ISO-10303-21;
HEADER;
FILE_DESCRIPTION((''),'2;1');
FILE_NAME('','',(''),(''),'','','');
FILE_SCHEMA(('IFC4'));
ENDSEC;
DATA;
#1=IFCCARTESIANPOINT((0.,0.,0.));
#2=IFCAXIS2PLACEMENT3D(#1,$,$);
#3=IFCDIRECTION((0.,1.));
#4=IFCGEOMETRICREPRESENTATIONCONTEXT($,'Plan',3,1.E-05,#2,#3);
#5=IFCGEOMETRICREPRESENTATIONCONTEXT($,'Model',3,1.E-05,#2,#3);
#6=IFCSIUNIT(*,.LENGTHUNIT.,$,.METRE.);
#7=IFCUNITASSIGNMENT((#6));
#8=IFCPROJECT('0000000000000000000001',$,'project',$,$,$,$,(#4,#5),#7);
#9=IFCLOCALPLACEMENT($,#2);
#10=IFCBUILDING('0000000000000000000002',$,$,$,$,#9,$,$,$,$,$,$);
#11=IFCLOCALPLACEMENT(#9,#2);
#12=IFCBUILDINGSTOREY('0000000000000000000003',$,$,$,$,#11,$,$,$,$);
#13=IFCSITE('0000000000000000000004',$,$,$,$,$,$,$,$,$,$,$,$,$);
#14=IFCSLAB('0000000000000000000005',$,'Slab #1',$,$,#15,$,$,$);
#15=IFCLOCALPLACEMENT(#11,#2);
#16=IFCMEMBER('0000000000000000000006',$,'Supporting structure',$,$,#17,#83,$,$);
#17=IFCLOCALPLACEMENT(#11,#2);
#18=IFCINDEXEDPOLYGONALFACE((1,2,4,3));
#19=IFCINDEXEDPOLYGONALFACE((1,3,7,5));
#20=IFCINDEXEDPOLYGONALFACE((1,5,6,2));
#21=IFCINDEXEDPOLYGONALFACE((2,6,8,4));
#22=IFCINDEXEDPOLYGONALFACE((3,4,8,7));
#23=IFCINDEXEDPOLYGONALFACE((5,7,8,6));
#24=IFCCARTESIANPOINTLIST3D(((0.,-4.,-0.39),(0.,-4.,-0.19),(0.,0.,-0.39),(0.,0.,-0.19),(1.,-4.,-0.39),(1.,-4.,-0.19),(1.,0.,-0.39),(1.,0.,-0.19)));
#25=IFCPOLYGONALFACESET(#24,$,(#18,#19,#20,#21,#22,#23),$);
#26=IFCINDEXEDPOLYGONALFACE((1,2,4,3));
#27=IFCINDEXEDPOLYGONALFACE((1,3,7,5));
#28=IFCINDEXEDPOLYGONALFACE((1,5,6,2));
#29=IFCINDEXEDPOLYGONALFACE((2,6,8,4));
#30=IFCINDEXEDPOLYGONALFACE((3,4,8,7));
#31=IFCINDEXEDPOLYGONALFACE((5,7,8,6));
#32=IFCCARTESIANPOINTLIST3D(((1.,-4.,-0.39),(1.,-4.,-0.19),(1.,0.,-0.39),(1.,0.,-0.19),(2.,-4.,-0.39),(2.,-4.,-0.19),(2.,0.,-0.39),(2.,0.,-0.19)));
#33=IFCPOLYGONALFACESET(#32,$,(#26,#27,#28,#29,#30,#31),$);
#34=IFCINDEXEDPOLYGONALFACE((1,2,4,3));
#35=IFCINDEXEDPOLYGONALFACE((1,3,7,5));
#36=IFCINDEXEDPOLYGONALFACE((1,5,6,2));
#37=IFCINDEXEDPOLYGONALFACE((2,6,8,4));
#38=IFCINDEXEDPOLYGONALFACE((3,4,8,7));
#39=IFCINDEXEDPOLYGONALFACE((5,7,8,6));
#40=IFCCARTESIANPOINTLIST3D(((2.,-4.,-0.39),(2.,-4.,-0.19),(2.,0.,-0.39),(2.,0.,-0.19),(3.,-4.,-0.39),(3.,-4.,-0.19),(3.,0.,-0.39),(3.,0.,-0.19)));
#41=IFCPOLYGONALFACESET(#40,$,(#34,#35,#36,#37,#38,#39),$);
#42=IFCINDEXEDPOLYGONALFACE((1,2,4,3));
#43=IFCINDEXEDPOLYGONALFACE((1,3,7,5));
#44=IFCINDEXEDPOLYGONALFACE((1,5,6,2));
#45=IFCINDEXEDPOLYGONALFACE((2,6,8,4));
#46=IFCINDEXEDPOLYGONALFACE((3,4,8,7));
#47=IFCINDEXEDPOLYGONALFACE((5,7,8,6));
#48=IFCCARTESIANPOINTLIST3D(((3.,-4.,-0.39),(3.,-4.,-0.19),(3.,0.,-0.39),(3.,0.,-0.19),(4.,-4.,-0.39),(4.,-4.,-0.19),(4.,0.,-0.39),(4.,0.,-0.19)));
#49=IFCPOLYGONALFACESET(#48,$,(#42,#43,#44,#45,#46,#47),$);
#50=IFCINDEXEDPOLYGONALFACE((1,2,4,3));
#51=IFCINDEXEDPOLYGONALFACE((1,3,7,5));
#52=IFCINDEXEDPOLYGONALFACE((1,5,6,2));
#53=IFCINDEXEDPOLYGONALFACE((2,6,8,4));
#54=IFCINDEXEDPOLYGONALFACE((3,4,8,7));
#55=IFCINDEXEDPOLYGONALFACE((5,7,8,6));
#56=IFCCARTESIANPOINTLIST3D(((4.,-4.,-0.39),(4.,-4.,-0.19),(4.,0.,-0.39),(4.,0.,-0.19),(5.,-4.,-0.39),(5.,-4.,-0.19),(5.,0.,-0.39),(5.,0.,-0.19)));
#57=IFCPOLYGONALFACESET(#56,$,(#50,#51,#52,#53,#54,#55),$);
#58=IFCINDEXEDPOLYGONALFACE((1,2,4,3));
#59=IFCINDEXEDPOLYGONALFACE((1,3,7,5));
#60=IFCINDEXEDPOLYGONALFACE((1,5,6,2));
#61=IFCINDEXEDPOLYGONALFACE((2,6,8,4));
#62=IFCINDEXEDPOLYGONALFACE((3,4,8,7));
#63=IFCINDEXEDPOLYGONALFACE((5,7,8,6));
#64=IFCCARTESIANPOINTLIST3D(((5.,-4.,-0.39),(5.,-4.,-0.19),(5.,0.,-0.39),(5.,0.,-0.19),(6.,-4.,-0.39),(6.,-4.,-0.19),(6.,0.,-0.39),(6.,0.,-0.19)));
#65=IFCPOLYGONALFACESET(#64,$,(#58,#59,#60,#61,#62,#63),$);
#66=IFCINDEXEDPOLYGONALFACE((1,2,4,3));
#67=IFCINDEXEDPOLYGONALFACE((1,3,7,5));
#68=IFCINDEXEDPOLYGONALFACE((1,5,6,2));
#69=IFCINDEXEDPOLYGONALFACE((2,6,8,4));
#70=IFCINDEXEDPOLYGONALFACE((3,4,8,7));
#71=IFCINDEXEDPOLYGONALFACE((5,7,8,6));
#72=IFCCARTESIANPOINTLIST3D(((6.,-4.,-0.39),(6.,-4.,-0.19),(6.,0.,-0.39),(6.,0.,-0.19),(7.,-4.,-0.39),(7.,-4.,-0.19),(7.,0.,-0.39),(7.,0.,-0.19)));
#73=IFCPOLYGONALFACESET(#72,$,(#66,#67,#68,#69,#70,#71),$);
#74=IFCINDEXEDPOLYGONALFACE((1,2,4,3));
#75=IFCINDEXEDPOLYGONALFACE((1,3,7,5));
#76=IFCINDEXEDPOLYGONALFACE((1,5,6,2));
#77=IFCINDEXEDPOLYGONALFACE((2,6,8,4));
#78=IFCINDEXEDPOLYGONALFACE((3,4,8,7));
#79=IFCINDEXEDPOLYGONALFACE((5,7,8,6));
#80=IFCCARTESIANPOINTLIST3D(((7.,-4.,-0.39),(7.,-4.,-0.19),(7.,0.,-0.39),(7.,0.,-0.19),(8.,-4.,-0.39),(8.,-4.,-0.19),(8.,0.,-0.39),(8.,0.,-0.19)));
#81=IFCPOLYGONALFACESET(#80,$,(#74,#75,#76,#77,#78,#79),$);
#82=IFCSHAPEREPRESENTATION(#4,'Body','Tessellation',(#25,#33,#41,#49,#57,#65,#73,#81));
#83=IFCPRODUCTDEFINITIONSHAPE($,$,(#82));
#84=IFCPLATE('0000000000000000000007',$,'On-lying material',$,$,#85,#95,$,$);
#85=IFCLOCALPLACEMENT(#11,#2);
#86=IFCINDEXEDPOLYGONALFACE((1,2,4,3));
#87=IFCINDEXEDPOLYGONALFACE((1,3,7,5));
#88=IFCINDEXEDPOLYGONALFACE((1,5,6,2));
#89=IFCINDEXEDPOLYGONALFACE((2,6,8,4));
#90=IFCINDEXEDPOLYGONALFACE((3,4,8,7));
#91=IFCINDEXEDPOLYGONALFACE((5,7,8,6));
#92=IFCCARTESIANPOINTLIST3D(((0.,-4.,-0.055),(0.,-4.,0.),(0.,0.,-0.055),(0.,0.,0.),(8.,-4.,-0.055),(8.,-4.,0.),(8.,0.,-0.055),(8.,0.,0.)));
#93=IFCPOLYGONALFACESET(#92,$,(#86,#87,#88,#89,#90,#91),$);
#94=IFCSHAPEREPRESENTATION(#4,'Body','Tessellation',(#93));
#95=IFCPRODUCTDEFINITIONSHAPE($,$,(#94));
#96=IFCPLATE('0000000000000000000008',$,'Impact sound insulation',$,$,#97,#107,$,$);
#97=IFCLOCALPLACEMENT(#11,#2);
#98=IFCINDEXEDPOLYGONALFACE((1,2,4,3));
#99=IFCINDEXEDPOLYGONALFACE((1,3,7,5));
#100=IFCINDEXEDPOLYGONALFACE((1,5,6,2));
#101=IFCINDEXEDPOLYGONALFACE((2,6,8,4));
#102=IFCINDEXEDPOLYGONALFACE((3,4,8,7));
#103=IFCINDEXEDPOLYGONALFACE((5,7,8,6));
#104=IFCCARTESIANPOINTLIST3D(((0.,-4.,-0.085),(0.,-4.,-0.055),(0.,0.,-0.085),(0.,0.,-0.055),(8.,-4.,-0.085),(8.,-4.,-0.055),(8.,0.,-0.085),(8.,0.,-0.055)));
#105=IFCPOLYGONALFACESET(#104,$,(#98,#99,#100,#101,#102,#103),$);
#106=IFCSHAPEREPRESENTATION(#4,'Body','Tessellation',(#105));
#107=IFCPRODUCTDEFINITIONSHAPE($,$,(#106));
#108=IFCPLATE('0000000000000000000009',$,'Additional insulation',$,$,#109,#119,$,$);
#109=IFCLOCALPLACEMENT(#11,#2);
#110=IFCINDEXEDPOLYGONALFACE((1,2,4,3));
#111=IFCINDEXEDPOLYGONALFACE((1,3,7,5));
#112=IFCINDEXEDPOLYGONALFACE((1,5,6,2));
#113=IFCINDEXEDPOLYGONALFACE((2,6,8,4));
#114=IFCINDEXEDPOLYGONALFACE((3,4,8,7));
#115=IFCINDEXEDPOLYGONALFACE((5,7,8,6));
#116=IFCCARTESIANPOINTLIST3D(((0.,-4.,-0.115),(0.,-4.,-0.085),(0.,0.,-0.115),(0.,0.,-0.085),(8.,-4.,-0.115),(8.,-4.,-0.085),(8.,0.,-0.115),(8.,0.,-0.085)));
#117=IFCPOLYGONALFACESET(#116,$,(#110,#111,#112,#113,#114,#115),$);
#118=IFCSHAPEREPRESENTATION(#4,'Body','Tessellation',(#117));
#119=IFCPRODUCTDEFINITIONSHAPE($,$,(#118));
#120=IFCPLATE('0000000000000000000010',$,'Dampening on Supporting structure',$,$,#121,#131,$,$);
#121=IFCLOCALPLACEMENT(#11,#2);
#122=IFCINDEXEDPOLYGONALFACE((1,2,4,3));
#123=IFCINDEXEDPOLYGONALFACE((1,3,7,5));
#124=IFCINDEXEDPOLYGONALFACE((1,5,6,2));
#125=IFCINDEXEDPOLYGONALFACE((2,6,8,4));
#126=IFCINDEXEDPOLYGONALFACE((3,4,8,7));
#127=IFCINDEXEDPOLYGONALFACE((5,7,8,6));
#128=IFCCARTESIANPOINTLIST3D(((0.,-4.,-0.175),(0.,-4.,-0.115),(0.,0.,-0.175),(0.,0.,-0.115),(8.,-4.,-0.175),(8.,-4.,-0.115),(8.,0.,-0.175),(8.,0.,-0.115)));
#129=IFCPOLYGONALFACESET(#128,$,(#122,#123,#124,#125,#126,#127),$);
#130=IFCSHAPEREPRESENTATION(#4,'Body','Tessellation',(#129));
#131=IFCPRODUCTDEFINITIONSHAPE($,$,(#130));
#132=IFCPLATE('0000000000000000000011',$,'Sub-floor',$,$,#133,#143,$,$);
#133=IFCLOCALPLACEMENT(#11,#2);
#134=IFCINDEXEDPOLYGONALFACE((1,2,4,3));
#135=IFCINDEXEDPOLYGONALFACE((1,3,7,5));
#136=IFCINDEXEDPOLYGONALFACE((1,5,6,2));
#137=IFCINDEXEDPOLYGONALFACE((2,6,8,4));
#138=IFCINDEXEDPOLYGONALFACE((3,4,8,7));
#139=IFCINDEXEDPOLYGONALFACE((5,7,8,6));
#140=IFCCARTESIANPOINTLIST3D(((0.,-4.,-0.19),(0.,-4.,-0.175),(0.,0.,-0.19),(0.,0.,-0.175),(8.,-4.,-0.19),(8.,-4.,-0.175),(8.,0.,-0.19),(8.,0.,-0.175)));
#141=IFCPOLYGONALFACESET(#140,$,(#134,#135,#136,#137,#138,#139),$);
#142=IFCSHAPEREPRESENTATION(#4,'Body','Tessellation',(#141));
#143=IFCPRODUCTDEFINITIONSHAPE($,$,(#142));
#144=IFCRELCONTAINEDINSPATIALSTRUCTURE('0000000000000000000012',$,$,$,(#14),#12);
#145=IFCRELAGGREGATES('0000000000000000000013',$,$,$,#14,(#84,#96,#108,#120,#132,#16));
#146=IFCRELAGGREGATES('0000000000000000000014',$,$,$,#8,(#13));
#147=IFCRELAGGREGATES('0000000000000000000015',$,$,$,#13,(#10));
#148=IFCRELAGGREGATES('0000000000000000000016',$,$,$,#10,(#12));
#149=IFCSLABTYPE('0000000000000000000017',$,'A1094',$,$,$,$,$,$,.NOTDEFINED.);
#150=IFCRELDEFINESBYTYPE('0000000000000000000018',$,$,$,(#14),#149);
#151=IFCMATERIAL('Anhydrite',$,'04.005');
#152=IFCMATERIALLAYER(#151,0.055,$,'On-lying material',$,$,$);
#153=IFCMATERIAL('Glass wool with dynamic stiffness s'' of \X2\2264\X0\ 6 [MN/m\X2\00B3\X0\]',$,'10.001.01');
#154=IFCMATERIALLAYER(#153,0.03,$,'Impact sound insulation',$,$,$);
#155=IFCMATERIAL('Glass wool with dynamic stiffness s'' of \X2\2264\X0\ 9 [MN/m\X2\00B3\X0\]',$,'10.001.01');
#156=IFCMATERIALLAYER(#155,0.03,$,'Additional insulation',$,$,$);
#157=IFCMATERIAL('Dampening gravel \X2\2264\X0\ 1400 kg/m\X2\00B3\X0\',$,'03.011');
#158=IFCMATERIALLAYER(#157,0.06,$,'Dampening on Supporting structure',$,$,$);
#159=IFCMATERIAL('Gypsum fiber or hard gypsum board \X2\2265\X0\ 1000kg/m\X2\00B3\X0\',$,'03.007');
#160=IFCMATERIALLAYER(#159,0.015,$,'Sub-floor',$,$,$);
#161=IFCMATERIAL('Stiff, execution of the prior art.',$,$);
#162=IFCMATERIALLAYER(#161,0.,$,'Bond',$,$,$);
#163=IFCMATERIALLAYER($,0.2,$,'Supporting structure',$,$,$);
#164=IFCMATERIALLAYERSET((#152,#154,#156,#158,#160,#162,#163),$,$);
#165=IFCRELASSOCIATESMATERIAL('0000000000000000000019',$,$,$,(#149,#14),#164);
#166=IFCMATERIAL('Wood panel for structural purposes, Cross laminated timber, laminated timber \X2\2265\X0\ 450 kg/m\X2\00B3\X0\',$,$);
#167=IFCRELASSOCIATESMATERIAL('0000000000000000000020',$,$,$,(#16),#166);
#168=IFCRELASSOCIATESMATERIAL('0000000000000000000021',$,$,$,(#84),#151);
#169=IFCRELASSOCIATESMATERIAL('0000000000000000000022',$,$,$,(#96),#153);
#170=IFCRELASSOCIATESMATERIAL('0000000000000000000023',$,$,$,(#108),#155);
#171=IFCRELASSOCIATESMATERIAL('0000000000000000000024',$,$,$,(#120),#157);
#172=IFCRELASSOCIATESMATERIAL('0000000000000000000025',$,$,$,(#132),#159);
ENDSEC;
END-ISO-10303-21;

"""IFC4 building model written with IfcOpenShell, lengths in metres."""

from ifc_helpers import new_model, si_unit, direction, frame, frame_2d, origin, origin_with_axes, place, context, project, spatial, rectangle, extrude, material, layer, layer_set, type_object, element, aggregate, save


model = new_model("IFC4")

# Units and contexts
plan_context = context("Plan", 3, precision=1e-05, world=origin(), true_north=direction((0.0, 1.0)))
model_context = context("Model", 3, precision=1e-05, world=origin(), true_north=direction((0.0, 1.0)))
ifc_project = project(units=[si_unit("LENGTHUNIT", "METRE")], contexts=[plan_context, model_context])

# Site, building, storey
site = spatial("IfcSite", under=ifc_project)
building_placement = place(None, origin())
building = spatial("IfcBuilding", under=site, at=building_placement)
storey_placement = place(building_placement, origin())
storey = spatial("IfcBuildingStorey", under=building, at=storey_placement)

# Slab, member, plates
ifc_material_1 = material(Name="Anhydrite", Category="04.005")
ifc_layer_1 = layer(ifc_material_1, 0.055, Name="On-lying material")
ifc_material_2 = material(Name="Glass wool with dynamic stiffness s' of ≤ 6 [MN/m³]", Category="10.001.01")
ifc_layer_2 = layer(ifc_material_2, 0.03, Name="Impact sound insulation")
ifc_material_3 = material(Name="Glass wool with dynamic stiffness s' of ≤ 9 [MN/m³]", Category="10.001.01")
ifc_layer_3 = layer(ifc_material_3, 0.03, Name="Additional insulation")
ifc_material_4 = material(Name="Dampening gravel ≤ 1400 kg/m³", Category="03.011")
ifc_layer_4 = layer(ifc_material_4, 0.06, Name="Dampening on Supporting structure")
ifc_material_5 = material(Name="Gypsum fiber or hard gypsum board ≥ 1000kg/m³", Category="03.007")
ifc_layer_5 = layer(ifc_material_5, 0.015, Name="Sub-floor")
ifc_material_6 = material(Name="Stiff, execution of the prior art.")
ifc_layer_6 = layer(ifc_material_6, 0.0, Name="Bond")
ifc_layer_7 = layer(None, 0.2, Name="Supporting structure")
ifc_layer_set = layer_set([ifc_layer_1, ifc_layer_2, ifc_layer_3, ifc_layer_4, ifc_layer_5, ifc_layer_6, ifc_layer_7])
slab_type = type_object("IfcSlabType", Name="A1094", PredefinedType="NOTDEFINED", material=ifc_layer_set)
slab_placement = place(None, frame((0.0, 0.0, 0.0), z_axis=(0.0, 0.0, -1.0), x_axis=(1.0, 0.0, 0.0)))
slab = element("IfcSlab", 1, at=slab_placement, inside=storey, type_object=slab_type, material=ifc_layer_set, Name="Slab #1")
ifc_material_7 = material(Name="Wood panel for structural purposes, Cross laminated timber, laminated timber ≥ 450 kg/m³")
member_placement = place(slab_placement, origin())
member = element("IfcMember", 2, at=member_placement, material=ifc_material_7, Name="Supporting structure", context=plan_context, shape_type="SweptSolid", body=[
    extrude(rectangle(XDim=1.0, YDim=0.2, at=frame_2d((0.5, 0.1), x_axis=(1.0, 0.0))), frame((0.0, 4.0, 0.19), z_axis=(0.0, -1.0, 0.0), x_axis=(1.0, 0.0, 0.0)), (0.0, 0.0, 1.0), 4.0),
    extrude(rectangle(XDim=1.0, YDim=0.2, at=frame_2d((0.5, 0.1), x_axis=(1.0, 0.0))), frame((1.0, 4.0, 0.19), z_axis=(0.0, -1.0, 0.0), x_axis=(1.0, 0.0, 0.0)), (0.0, 0.0, 1.0), 4.0),
    extrude(rectangle(XDim=1.0, YDim=0.2, at=frame_2d((0.5, 0.1), x_axis=(1.0, 0.0))), frame((2.0, 4.0, 0.19), z_axis=(0.0, -1.0, 0.0), x_axis=(1.0, 0.0, 0.0)), (0.0, 0.0, 1.0), 4.0),
    extrude(rectangle(XDim=1.0, YDim=0.2, at=frame_2d((0.5, 0.1), x_axis=(1.0, 0.0))), frame((3.0, 4.0, 0.19), z_axis=(0.0, -1.0, 0.0), x_axis=(1.0, 0.0, 0.0)), (0.0, 0.0, 1.0), 4.0),
    extrude(rectangle(XDim=1.0, YDim=0.2, at=frame_2d((0.5, 0.1), x_axis=(1.0, 0.0))), frame((4.0, 4.0, 0.19), z_axis=(0.0, -1.0, 0.0), x_axis=(1.0, 0.0, 0.0)), (0.0, 0.0, 1.0), 4.0),
    extrude(rectangle(XDim=1.0, YDim=0.2, at=frame_2d((0.5, 0.1), x_axis=(1.0, 0.0))), frame((5.0, 4.0, 0.19), z_axis=(0.0, -1.0, 0.0), x_axis=(1.0, 0.0, 0.0)), (0.0, 0.0, 1.0), 4.0),
    extrude(rectangle(XDim=1.0, YDim=0.2, at=frame_2d((0.5, 0.1), x_axis=(1.0, 0.0))), frame((6.0, 4.0, 0.19), z_axis=(0.0, -1.0, 0.0), x_axis=(1.0, 0.0, 0.0)), (0.0, 0.0, 1.0), 4.0),
    extrude(rectangle(XDim=1.0, YDim=0.2, at=frame_2d((0.5, 0.1), x_axis=(1.0, 0.0))), frame((7.0, 4.0, 0.19), z_axis=(0.0, -1.0, 0.0), x_axis=(1.0, 0.0, 0.0)), (0.0, 0.0, 1.0), 4.0),
])
plate_1_placement = place(slab_placement, origin())
plate_1 = element("IfcPlate", 3, at=plate_1_placement, material=ifc_material_1, Name="On-lying material", context=plan_context, shape_type="SweptSolid", body=[
    extrude(rectangle(XDim=8.0, YDim=4.0, at=frame_2d((4.0, 2.0), x_axis=(1.0, 0.0))), origin_with_axes(), (0.0, 0.0, 1.0), 0.055),
])
plate_2_placement = place(slab_placement, origin())
plate_2 = element("IfcPlate", 4, at=plate_2_placement, material=ifc_material_2, Name="Impact sound insulation", context=plan_context, shape_type="SweptSolid", body=[
    extrude(rectangle(XDim=8.0, YDim=4.0, at=frame_2d((4.0, 2.0), x_axis=(1.0, 0.0))), frame((0.0, 0.0, 0.055), z_axis=(0.0, 0.0, 1.0), x_axis=(1.0, 0.0, 0.0)), (0.0, 0.0, 1.0), 0.03),
])
plate_3_placement = place(slab_placement, origin())
plate_3 = element("IfcPlate", 5, at=plate_3_placement, material=ifc_material_3, Name="Additional insulation", context=plan_context, shape_type="SweptSolid", body=[
    extrude(rectangle(XDim=8.0, YDim=4.0, at=frame_2d((4.0, 2.0), x_axis=(1.0, 0.0))), frame((0.0, 0.0, 0.085), z_axis=(0.0, 0.0, 1.0), x_axis=(1.0, 0.0, 0.0)), (0.0, 0.0, 1.0), 0.03),
])
plate_4_placement = place(slab_placement, origin())
plate_4 = element("IfcPlate", 6, at=plate_4_placement, material=ifc_material_4, Name="Dampening on Supporting structure", context=plan_context, shape_type="SweptSolid", body=[
    extrude(rectangle(XDim=8.0, YDim=4.0, at=frame_2d((4.0, 2.0), x_axis=(1.0, 0.0))), frame((0.0, 0.0, 0.115), z_axis=(0.0, 0.0, 1.0), x_axis=(1.0, 0.0, 0.0)), (0.0, 0.0, 1.0), 0.06),
])
plate_5_placement = place(slab_placement, origin())
plate_5 = element("IfcPlate", 7, at=plate_5_placement, material=ifc_material_5, Name="Sub-floor", context=plan_context, shape_type="SweptSolid", body=[
    extrude(rectangle(XDim=8.0, YDim=4.0, at=frame_2d((4.0, 2.0), x_axis=(1.0, 0.0))), frame((0.0, 0.0, 0.175), z_axis=(0.0, 0.0, 1.0), x_axis=(1.0, 0.0, 0.0)), (0.0, 0.0, 1.0), 0.015),
])
aggregate(slab, [plate_1, plate_2, plate_3, plate_4, plate_5, member])

save(model, "model.ifc")
